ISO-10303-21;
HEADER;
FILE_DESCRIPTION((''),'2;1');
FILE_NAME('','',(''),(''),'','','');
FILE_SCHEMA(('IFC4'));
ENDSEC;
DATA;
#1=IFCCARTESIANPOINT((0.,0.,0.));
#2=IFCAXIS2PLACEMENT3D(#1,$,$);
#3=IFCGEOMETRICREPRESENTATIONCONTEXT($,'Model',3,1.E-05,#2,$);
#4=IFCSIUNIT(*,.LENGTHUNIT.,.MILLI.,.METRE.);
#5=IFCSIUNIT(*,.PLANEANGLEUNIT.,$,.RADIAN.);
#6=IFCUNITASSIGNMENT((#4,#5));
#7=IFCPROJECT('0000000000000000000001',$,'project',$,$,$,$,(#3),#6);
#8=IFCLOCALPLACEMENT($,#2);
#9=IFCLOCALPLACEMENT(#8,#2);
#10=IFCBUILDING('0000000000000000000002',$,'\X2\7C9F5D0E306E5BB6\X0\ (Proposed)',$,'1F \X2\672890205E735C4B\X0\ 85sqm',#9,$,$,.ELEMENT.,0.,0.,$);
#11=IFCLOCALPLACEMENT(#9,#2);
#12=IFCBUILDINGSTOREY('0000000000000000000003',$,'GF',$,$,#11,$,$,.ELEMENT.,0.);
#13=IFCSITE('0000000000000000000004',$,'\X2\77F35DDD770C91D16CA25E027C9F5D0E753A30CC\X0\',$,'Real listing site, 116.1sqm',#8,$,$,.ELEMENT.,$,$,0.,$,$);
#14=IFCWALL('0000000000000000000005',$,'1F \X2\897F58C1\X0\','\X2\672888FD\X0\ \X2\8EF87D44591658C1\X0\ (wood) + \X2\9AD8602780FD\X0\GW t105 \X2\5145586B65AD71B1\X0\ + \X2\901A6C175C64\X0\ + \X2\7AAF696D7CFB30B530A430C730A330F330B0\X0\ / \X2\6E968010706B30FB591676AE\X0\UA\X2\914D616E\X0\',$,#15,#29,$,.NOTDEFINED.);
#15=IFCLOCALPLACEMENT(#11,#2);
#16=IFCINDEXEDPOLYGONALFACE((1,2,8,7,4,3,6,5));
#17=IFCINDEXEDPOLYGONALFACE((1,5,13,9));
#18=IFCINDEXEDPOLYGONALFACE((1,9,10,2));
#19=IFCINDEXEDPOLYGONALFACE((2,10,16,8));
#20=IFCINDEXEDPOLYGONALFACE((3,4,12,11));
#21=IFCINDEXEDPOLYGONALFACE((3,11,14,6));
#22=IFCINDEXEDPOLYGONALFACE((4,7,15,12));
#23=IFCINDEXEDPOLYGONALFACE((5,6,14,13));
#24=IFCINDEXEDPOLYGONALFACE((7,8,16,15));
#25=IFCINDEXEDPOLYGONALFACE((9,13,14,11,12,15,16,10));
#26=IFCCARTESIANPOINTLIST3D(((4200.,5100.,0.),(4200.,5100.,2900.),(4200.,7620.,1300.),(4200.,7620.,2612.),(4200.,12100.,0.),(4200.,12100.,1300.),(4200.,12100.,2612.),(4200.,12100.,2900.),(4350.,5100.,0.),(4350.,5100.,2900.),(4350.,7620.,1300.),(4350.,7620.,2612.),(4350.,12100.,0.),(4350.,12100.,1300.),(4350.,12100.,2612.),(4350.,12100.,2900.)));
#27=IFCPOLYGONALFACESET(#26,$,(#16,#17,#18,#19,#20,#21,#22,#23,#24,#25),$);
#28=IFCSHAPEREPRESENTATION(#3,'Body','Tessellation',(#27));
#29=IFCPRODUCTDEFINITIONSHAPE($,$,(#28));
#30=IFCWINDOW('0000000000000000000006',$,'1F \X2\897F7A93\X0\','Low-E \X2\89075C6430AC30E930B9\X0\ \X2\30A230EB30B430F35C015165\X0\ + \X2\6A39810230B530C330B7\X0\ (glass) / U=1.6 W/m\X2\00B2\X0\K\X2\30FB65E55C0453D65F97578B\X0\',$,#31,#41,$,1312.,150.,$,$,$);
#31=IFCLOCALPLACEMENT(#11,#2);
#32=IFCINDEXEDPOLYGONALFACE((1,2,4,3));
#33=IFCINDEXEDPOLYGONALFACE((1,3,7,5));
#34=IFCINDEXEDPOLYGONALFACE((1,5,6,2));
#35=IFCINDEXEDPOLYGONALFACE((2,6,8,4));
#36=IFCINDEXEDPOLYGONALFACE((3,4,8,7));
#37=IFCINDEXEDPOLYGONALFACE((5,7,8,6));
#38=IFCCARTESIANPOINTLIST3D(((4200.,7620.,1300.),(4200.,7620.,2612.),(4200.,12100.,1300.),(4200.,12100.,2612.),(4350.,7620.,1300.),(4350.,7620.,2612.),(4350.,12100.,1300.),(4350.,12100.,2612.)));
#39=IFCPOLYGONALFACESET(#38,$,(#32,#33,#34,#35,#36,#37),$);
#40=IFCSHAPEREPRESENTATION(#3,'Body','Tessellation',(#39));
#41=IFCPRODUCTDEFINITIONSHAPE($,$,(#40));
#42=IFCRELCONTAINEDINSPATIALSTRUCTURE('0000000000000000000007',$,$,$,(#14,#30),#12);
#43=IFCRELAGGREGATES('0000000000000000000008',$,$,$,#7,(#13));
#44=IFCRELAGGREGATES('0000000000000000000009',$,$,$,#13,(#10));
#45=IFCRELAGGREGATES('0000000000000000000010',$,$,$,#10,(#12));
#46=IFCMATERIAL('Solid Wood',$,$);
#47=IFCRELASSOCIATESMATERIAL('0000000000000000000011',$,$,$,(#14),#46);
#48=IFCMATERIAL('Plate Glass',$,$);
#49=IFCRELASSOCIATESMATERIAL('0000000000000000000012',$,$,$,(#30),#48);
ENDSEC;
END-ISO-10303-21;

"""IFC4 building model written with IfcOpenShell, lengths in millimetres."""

from ifc_helpers import new_model, si_unit, frame, frame_2d, origin, place, context, project, spatial, rectangle, extrude, material, element, fill, save


model = new_model("IFC4")

# Units and contexts
model_context = context("Model", 3, precision=1e-05, world=origin())
ifc_project = project(units=[si_unit("LENGTHUNIT", "METRE", prefix="MILLI"), si_unit("PLANEANGLEUNIT", "RADIAN")], contexts=[model_context])

# Site, building, storey
site_placement = place(None, origin())
site = spatial("IfcSite", under=ifc_project, at=site_placement, Name="石川県金沢市粟崎町ヌ", ObjectType="Real listing site, 116.1sqm", CompositionType="ELEMENT", RefElevation=0.0)
building_placement = place(site_placement, origin())
building = spatial("IfcBuilding", under=site, at=building_placement, Name="粟崎の家 (Proposed)", ObjectType="1F 木造平屋 85sqm", CompositionType="ELEMENT", ElevationOfRefHeight=0.0, ElevationOfTerrain=0.0)
storey_placement = place(building_placement, origin())
storey = spatial("IfcBuildingStorey", under=building, at=storey_placement, Name="GF", CompositionType="ELEMENT", Elevation=0.0)

# Shared definitions
ifc_material_1 = material(Name="Solid Wood")

# Shared definitions
ifc_material_2 = material(Name="Plate Glass")

# Wall, opening, window
wall_1_placement = place(storey_placement, frame((2100.0, 2550.0, 0.0)))
wall_1 = element("IfcWall", 1, at=wall_1_placement, inside=storey, material=ifc_material_1, Name="1F 西壁", Description="木製 軸組外壁 (wood) + 高性能GW t105 充填断熱 + 通気層 + 窯業系サイディング / 準耐火・外皮UA配慮", PredefinedType="NOTDEFINED", context=model_context, shape_type="SweptSolid", body=[
    extrude(rectangle(XDim=150.0, YDim=7000.0, at=frame_2d((75.0, 3500.0))), frame((2100.0, 2550.0, 0.0)), (0.0, 0.0, 1.0), 2900.0),
])
opening_1_placement = place(storey_placement, frame((2100.0, 3810.0, 650.0)))
opening_1 = element("IfcOpeningElement", 2, at=opening_1_placement, cuts=wall_1, PredefinedType="NOTDEFINED", context=model_context, shape_type="SweptSolid", body=[
    extrude(rectangle(XDim=150.0, YDim=4480.0, at=frame_2d((75.0, 2240.0))), frame((2100.0, 3810.0, 650.0)), (0.0, 0.0, 1.0), 1312.0),
])
window_1_placement = place(storey_placement, frame((2100.0, 3810.0, 650.0)))
window_1 = element("IfcWindow", 3, at=window_1_placement, inside=storey, material=ifc_material_2, Name="1F 西窓", Description="Low-E 複層ガラス アルゴン封入 + 樹脂サッシ (glass) / U=1.6 W/m²K・日射取得型", OverallHeight=1312.0, OverallWidth=150.0, context=model_context, shape_type="SweptSolid", body=[
    extrude(rectangle(XDim=150.0, YDim=4480.0, at=frame_2d((75.0, 2240.0))), frame((2100.0, 3810.0, 650.0)), (0.0, 0.0, 1.0), 1312.0),
])
fill(opening_1, window_1)

save(model, "model.ifc")
